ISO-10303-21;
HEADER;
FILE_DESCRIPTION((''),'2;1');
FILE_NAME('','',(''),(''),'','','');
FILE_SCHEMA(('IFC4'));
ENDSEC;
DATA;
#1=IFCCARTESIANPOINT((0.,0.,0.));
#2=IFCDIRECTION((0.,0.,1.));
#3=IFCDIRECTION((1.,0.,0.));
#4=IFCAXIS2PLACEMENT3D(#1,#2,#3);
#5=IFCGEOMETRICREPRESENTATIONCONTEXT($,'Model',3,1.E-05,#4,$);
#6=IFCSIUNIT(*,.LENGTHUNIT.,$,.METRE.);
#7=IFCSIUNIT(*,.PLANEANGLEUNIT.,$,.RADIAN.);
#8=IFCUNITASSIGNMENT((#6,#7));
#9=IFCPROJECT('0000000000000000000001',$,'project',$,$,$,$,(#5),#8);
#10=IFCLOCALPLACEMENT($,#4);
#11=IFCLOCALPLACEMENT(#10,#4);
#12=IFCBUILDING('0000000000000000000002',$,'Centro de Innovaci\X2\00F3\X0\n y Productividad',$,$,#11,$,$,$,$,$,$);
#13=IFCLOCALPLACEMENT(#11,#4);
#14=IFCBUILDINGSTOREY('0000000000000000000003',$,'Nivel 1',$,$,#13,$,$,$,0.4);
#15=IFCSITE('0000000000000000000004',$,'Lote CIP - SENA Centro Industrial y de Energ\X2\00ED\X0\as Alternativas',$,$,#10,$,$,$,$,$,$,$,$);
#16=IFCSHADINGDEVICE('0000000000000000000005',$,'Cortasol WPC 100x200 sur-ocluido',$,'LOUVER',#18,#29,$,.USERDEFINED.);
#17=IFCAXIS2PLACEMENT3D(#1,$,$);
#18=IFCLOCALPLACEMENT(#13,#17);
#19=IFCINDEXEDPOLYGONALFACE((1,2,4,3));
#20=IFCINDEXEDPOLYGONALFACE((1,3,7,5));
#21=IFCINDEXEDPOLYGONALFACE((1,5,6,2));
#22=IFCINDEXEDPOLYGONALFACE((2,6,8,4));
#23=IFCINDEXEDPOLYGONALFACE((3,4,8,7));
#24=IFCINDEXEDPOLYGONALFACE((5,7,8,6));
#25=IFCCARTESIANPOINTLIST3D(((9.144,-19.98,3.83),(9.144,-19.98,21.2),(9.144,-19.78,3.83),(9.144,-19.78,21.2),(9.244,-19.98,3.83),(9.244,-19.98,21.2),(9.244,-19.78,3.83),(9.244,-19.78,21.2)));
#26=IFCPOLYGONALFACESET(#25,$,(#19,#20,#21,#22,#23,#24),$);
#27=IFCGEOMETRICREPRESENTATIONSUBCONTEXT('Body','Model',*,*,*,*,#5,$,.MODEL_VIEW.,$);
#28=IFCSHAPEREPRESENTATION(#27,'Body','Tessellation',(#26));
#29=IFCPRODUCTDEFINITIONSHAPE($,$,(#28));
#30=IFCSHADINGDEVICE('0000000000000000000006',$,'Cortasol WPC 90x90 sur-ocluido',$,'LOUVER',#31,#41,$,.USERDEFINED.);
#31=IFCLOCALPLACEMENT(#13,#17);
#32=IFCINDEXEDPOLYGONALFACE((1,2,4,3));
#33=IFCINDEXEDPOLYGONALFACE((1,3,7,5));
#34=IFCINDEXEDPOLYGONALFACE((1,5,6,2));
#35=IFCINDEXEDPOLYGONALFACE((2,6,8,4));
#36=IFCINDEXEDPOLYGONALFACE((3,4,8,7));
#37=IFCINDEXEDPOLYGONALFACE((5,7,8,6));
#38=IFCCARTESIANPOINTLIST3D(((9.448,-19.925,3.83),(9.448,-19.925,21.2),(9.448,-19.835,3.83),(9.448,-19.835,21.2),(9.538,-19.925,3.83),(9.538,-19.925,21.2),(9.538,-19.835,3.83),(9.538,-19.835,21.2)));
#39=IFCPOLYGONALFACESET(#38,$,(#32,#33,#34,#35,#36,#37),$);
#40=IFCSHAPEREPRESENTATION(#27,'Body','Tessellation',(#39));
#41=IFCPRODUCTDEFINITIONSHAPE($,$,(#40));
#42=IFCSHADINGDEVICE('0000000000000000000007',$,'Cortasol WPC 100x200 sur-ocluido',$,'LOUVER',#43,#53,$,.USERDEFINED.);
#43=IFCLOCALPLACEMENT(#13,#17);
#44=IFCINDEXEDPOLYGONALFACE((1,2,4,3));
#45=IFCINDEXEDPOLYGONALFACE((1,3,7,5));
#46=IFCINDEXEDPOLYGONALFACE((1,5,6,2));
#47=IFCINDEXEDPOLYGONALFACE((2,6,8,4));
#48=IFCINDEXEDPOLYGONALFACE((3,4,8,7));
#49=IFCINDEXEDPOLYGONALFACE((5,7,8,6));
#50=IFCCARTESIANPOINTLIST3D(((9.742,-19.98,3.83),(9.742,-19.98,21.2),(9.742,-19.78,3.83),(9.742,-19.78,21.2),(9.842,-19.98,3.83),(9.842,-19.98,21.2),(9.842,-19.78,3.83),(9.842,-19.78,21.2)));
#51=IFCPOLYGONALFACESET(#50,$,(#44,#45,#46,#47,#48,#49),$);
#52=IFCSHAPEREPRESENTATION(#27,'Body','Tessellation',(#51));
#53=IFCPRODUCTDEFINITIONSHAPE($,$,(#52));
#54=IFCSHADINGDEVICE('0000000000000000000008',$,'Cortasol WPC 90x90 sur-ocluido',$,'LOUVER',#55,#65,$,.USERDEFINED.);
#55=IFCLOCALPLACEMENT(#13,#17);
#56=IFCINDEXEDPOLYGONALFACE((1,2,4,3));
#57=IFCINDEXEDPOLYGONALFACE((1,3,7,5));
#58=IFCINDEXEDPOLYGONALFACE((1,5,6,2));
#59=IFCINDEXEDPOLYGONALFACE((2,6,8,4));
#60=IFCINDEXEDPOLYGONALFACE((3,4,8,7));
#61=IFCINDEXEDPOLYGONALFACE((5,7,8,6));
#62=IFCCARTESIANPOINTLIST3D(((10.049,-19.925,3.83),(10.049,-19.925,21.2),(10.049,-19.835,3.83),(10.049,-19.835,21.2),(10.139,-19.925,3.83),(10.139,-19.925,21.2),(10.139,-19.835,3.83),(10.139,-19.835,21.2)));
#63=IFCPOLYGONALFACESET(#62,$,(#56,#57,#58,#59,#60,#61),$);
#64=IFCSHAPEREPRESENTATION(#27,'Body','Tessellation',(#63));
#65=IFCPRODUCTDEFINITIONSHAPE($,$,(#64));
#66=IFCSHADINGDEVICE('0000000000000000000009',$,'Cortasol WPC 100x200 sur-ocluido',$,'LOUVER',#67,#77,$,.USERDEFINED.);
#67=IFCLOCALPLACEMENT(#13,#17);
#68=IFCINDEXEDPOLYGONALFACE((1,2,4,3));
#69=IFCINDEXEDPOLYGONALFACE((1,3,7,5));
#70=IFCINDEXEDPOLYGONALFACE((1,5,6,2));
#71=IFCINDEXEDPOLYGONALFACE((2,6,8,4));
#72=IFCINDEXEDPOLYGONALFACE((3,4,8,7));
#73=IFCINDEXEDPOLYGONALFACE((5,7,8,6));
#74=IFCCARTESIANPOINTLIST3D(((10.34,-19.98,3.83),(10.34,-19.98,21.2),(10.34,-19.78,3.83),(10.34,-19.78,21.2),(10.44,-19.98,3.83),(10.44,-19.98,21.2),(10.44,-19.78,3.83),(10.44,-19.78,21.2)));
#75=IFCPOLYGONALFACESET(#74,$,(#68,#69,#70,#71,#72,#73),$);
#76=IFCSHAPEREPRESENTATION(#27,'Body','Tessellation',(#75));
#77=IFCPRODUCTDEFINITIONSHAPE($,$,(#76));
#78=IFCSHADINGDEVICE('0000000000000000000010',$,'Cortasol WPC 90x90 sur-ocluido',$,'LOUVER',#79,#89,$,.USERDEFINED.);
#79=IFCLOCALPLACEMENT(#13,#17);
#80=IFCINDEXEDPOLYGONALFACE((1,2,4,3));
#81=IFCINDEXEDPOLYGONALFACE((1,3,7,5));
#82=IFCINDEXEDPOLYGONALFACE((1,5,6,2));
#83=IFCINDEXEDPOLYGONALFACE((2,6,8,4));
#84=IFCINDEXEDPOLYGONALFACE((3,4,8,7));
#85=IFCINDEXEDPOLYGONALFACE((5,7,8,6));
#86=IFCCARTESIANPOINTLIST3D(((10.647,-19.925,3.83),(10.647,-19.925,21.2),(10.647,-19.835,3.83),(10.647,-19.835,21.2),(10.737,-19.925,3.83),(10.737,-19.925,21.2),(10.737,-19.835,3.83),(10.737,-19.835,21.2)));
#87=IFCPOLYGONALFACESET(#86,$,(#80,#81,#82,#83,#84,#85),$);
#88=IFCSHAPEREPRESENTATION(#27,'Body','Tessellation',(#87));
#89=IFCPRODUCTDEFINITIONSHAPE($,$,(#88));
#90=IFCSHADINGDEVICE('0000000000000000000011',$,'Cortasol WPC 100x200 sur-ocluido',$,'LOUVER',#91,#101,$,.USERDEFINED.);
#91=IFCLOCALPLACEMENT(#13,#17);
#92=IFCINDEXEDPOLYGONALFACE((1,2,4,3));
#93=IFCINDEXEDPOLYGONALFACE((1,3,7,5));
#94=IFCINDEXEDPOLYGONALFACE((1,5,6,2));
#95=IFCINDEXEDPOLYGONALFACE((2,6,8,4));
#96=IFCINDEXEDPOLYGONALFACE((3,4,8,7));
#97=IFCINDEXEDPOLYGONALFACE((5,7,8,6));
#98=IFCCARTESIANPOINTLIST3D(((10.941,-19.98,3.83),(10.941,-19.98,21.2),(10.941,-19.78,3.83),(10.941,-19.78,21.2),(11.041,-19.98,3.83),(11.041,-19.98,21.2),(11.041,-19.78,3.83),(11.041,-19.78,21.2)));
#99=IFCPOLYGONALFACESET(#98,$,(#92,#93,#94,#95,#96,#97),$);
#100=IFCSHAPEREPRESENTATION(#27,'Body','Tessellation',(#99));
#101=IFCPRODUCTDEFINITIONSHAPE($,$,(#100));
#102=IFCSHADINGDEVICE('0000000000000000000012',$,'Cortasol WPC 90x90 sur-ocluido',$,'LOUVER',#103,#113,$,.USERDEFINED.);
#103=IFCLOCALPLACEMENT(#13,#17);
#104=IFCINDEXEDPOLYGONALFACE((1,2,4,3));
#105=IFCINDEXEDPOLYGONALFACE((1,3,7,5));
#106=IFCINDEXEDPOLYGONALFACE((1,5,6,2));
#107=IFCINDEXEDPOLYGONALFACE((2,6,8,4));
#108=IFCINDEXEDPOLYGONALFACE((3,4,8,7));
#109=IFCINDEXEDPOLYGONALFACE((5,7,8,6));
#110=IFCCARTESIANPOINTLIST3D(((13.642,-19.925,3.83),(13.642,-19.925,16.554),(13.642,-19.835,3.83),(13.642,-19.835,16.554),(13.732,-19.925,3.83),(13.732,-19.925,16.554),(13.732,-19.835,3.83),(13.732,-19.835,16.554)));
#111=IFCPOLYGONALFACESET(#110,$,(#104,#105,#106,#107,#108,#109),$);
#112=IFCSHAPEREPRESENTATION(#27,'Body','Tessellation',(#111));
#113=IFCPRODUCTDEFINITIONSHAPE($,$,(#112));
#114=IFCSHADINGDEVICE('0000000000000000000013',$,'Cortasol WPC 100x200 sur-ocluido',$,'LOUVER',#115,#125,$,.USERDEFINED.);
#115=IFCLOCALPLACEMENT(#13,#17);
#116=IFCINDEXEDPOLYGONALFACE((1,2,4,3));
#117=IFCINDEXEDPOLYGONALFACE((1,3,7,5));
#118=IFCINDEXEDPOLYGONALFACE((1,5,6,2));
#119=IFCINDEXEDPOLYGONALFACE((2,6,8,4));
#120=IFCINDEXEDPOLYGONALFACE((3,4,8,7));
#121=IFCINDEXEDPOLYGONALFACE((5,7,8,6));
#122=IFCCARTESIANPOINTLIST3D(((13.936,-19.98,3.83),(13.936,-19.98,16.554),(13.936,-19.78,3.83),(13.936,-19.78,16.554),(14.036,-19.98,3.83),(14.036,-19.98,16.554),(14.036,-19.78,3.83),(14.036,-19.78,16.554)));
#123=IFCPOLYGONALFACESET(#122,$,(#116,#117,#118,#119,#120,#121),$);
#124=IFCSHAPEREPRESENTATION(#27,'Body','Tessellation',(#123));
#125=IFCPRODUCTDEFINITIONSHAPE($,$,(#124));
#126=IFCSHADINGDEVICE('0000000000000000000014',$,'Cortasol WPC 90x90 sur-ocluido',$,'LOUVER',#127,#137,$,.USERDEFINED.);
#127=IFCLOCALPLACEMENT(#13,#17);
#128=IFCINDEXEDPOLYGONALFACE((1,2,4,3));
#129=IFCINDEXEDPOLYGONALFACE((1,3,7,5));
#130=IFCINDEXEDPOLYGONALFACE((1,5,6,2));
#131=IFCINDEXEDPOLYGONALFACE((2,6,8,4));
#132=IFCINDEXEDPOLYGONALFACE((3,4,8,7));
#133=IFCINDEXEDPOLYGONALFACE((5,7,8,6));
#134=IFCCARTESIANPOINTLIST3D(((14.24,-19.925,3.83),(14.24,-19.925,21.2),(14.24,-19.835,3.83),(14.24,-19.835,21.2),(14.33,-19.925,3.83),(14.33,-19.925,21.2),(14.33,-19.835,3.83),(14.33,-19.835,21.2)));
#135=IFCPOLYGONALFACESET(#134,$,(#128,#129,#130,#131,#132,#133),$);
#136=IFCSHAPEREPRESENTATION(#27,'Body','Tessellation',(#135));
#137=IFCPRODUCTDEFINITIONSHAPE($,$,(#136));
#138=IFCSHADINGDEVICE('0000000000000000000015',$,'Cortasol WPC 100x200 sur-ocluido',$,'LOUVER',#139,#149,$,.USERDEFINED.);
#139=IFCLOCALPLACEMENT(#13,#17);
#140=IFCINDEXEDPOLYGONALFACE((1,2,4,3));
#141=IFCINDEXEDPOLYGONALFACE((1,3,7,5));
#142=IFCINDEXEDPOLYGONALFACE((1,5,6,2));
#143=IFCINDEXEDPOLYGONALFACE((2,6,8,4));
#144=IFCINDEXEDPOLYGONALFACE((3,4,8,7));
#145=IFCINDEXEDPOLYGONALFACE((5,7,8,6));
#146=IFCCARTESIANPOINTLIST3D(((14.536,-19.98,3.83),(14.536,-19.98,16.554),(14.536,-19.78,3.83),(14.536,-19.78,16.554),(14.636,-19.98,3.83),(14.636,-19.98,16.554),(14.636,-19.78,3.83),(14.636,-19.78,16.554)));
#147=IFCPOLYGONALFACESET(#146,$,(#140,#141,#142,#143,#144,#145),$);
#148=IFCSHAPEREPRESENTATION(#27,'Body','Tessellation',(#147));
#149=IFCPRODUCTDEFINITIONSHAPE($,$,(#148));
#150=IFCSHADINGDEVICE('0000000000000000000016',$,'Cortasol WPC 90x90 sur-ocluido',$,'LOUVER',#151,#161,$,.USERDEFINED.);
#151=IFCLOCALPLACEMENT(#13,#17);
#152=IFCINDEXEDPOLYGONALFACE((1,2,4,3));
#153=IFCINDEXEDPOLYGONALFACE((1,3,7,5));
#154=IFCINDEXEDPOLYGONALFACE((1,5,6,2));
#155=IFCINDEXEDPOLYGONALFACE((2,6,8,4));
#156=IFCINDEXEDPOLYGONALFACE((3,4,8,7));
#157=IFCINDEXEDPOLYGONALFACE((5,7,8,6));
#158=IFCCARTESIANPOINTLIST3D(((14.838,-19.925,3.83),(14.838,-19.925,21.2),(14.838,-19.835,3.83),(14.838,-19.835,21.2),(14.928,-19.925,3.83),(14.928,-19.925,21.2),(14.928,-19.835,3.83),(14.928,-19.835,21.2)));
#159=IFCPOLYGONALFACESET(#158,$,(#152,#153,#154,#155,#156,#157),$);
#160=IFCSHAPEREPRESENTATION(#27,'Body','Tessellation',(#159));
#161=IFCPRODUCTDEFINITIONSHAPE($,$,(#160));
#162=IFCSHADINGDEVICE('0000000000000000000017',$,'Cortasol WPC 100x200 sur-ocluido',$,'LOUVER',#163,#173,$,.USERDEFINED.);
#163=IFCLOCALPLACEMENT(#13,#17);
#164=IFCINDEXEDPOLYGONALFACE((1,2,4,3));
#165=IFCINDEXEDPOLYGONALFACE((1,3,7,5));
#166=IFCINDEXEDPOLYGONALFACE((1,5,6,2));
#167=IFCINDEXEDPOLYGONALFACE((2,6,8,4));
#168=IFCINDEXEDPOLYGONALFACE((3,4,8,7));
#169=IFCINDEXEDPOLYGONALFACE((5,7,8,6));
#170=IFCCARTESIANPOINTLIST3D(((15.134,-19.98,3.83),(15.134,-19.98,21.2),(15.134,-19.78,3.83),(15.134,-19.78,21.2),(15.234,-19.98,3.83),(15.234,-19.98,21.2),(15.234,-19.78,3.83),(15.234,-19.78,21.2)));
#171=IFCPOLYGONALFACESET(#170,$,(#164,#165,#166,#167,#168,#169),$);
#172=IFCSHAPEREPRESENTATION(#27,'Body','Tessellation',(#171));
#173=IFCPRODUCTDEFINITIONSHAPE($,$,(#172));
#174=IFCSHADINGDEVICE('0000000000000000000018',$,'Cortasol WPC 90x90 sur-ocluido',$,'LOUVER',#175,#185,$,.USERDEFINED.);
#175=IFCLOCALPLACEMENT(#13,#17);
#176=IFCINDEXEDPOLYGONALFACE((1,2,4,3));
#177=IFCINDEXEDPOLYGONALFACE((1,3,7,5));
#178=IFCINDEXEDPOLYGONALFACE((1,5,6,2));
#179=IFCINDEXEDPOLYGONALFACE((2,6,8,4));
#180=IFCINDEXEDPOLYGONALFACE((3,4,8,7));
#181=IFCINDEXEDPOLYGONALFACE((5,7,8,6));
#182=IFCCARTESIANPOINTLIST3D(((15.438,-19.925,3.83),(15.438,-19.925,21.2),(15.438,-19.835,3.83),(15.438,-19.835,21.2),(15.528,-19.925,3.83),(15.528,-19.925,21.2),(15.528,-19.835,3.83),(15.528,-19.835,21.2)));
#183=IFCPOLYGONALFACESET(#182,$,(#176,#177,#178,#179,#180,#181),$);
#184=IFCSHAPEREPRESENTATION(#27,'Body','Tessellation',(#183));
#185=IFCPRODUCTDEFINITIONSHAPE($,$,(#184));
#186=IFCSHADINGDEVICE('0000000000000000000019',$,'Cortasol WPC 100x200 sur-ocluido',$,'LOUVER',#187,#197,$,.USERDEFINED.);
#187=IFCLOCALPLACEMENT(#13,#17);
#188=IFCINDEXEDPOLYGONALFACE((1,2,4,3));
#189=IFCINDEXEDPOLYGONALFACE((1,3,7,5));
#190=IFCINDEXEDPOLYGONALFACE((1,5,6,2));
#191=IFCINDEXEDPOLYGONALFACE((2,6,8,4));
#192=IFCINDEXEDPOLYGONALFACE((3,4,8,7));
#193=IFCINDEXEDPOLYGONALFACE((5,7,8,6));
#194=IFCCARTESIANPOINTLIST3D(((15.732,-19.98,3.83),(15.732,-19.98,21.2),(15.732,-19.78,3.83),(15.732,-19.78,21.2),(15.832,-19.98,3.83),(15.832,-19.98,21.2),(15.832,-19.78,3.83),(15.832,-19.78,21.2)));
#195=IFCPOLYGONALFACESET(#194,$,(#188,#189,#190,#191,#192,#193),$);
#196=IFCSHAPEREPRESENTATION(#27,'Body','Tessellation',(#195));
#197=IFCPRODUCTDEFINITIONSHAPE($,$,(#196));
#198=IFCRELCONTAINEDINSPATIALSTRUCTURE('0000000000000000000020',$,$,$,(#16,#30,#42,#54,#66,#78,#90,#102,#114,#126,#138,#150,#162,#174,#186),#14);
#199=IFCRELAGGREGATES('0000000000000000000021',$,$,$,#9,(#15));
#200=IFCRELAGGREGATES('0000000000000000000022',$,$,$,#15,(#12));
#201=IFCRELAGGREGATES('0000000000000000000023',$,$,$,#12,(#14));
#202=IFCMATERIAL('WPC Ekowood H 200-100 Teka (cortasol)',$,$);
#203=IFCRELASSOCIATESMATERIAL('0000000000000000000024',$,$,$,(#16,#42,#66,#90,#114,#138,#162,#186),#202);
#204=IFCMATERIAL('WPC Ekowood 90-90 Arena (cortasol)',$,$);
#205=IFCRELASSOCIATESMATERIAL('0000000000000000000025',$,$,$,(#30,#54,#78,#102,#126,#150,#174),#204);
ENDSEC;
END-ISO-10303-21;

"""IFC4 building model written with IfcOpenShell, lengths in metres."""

from ifc_helpers import new_model, si_unit, frame, origin_with_axes, place, context, subcontext, project, spatial, polyline, outline, extrude, material, element, save


model = new_model("IFC4")

# Units and contexts
model_context = context("Model", 3, precision=1e-05, world=origin_with_axes())
body_context = subcontext(model_context, "Body", "Model", "MODEL_VIEW")
ifc_project = project(units=[si_unit("LENGTHUNIT", "METRE"), si_unit("PLANEANGLEUNIT", "RADIAN")], contexts=[model_context])

# Site, building, storey
site_placement = place(None, origin_with_axes())
site = spatial("IfcSite", under=ifc_project, at=site_placement, Name="Lote CIP - SENA Centro Industrial y de Energías Alternativas")
building_placement = place(site_placement, origin_with_axes())
building = spatial("IfcBuilding", under=site, at=building_placement, Name="Centro de Innovación y Productividad")
storey_placement = place(building_placement, origin_with_axes())
storey = spatial("IfcBuildingStorey", under=building, at=storey_placement, Name="Nivel 1", Elevation=0.4)

# Shading devices
ifc_material_1 = material(Name="WPC Ekowood H 200-100 Teka (cortasol)")
shading_device_1_placement = place(storey_placement, origin_with_axes())
element("IfcShadingDevice", 1, at=shading_device_1_placement, inside=storey, material=ifc_material_1, Name="Cortasol WPC 100x200 sur-ocluido", ObjectType="LOUVER", PredefinedType="USERDEFINED", context=body_context, shape_type="SweptSolid", body=[
    extrude(outline(polyline([(9.144, -19.98), (9.144, -19.78), (9.244, -19.78), (9.244, -19.98), (9.144, -19.98)])), frame((0.0, 0.0, 3.83)), (0.0, 0.0, 1.0), 17.37),
])
ifc_material_2 = material(Name="WPC Ekowood 90-90 Arena (cortasol)")
shading_device_2_placement = place(storey_placement, origin_with_axes())
element("IfcShadingDevice", 2, at=shading_device_2_placement, inside=storey, material=ifc_material_2, Name="Cortasol WPC 90x90 sur-ocluido", ObjectType="LOUVER", PredefinedType="USERDEFINED", context=body_context, shape_type="SweptSolid", body=[
    extrude(outline(polyline([(9.448, -19.925), (9.448, -19.835), (9.538, -19.835), (9.538, -19.925), (9.448, -19.925)])), frame((0.0, 0.0, 3.83)), (0.0, 0.0, 1.0), 17.37),
])
shading_device_3_placement = place(storey_placement, origin_with_axes())
element("IfcShadingDevice", 3, at=shading_device_3_placement, inside=storey, material=ifc_material_1, Name="Cortasol WPC 100x200 sur-ocluido", ObjectType="LOUVER", PredefinedType="USERDEFINED", context=body_context, shape_type="SweptSolid", body=[
    extrude(outline(polyline([(9.742, -19.98), (9.742, -19.78), (9.842, -19.78), (9.842, -19.98), (9.742, -19.98)])), frame((0.0, 0.0, 3.83)), (0.0, 0.0, 1.0), 17.37),
])
shading_device_4_placement = place(storey_placement, origin_with_axes())
element("IfcShadingDevice", 4, at=shading_device_4_placement, inside=storey, material=ifc_material_2, Name="Cortasol WPC 90x90 sur-ocluido", ObjectType="LOUVER", PredefinedType="USERDEFINED", context=body_context, shape_type="SweptSolid", body=[
    extrude(outline(polyline([(10.049, -19.925), (10.049, -19.835), (10.139, -19.835), (10.139, -19.925), (10.049, -19.925)])), frame((0.0, 0.0, 3.83)), (0.0, 0.0, 1.0), 17.37),
])
shading_device_5_placement = place(storey_placement, origin_with_axes())
element("IfcShadingDevice", 5, at=shading_device_5_placement, inside=storey, material=ifc_material_1, Name="Cortasol WPC 100x200 sur-ocluido", ObjectType="LOUVER", PredefinedType="USERDEFINED", context=body_context, shape_type="SweptSolid", body=[
    extrude(outline(polyline([(10.34, -19.98), (10.34, -19.78), (10.44, -19.78), (10.44, -19.98), (10.34, -19.98)])), frame((0.0, 0.0, 3.83)), (0.0, 0.0, 1.0), 17.37),
])
shading_device_6_placement = place(storey_placement, origin_with_axes())
element("IfcShadingDevice", 6, at=shading_device_6_placement, inside=storey, material=ifc_material_2, Name="Cortasol WPC 90x90 sur-ocluido", ObjectType="LOUVER", PredefinedType="USERDEFINED", context=body_context, shape_type="SweptSolid", body=[
    extrude(outline(polyline([(10.647, -19.925), (10.647, -19.835), (10.737, -19.835), (10.737, -19.925), (10.647, -19.925)])), frame((0.0, 0.0, 3.83)), (0.0, 0.0, 1.0), 17.37),
])
shading_device_7_placement = place(storey_placement, origin_with_axes())
element("IfcShadingDevice", 7, at=shading_device_7_placement, inside=storey, material=ifc_material_1, Name="Cortasol WPC 100x200 sur-ocluido", ObjectType="LOUVER", PredefinedType="USERDEFINED", context=body_context, shape_type="SweptSolid", body=[
    extrude(outline(polyline([(10.941, -19.98), (10.941, -19.78), (11.041, -19.78), (11.041, -19.98), (10.941, -19.98)])), frame((0.0, 0.0, 3.83)), (0.0, 0.0, 1.0), 17.37),
])
shading_device_8_placement = place(storey_placement, origin_with_axes())
element("IfcShadingDevice", 8, at=shading_device_8_placement, inside=storey, material=ifc_material_2, Name="Cortasol WPC 90x90 sur-ocluido", ObjectType="LOUVER", PredefinedType="USERDEFINED", context=body_context, shape_type="SweptSolid", body=[
    extrude(outline(polyline([(13.642, -19.925), (13.642, -19.835), (13.732, -19.835), (13.732, -19.925), (13.642, -19.925)])), frame((0.0, 0.0, 3.83)), (0.0, 0.0, 1.0), 12.724),
])
shading_device_9_placement = place(storey_placement, origin_with_axes())
element("IfcShadingDevice", 9, at=shading_device_9_placement, inside=storey, material=ifc_material_1, Name="Cortasol WPC 100x200 sur-ocluido", ObjectType="LOUVER", PredefinedType="USERDEFINED", context=body_context, shape_type="SweptSolid", body=[
    extrude(outline(polyline([(13.936, -19.98), (13.936, -19.78), (14.036, -19.78), (14.036, -19.98), (13.936, -19.98)])), frame((0.0, 0.0, 3.83)), (0.0, 0.0, 1.0), 12.724),
])
shading_device_10_placement = place(storey_placement, origin_with_axes())
element("IfcShadingDevice", 10, at=shading_device_10_placement, inside=storey, material=ifc_material_2, Name="Cortasol WPC 90x90 sur-ocluido", ObjectType="LOUVER", PredefinedType="USERDEFINED", context=body_context, shape_type="SweptSolid", body=[
    extrude(outline(polyline([(14.24, -19.925), (14.24, -19.835), (14.33, -19.835), (14.33, -19.925), (14.24, -19.925)])), frame((0.0, 0.0, 3.83)), (0.0, 0.0, 1.0), 17.37),
])
shading_device_11_placement = place(storey_placement, origin_with_axes())
element("IfcShadingDevice", 11, at=shading_device_11_placement, inside=storey, material=ifc_material_1, Name="Cortasol WPC 100x200 sur-ocluido", ObjectType="LOUVER", PredefinedType="USERDEFINED", context=body_context, shape_type="SweptSolid", body=[
    extrude(outline(polyline([(14.536, -19.98), (14.536, -19.78), (14.636, -19.78), (14.636, -19.98), (14.536, -19.98)])), frame((0.0, 0.0, 3.83)), (0.0, 0.0, 1.0), 12.724),
])
shading_device_12_placement = place(storey_placement, origin_with_axes())
element("IfcShadingDevice", 12, at=shading_device_12_placement, inside=storey, material=ifc_material_2, Name="Cortasol WPC 90x90 sur-ocluido", ObjectType="LOUVER", PredefinedType="USERDEFINED", context=body_context, shape_type="SweptSolid", body=[
    extrude(outline(polyline([(14.838, -19.925), (14.838, -19.835), (14.928, -19.835), (14.928, -19.925), (14.838, -19.925)])), frame((0.0, 0.0, 3.83)), (0.0, 0.0, 1.0), 17.37),
])
shading_device_13_placement = place(storey_placement, origin_with_axes())
element("IfcShadingDevice", 13, at=shading_device_13_placement, inside=storey, material=ifc_material_1, Name="Cortasol WPC 100x200 sur-ocluido", ObjectType="LOUVER", PredefinedType="USERDEFINED", context=body_context, shape_type="SweptSolid", body=[
    extrude(outline(polyline([(15.134, -19.98), (15.134, -19.78), (15.234, -19.78), (15.234, -19.98), (15.134, -19.98)])), frame((0.0, 0.0, 3.83)), (0.0, 0.0, 1.0), 17.37),
])
shading_device_14_placement = place(storey_placement, origin_with_axes())
element("IfcShadingDevice", 14, at=shading_device_14_placement, inside=storey, material=ifc_material_2, Name="Cortasol WPC 90x90 sur-ocluido", ObjectType="LOUVER", PredefinedType="USERDEFINED", context=body_context, shape_type="SweptSolid", body=[
    extrude(outline(polyline([(15.438, -19.925), (15.438, -19.835), (15.528, -19.835), (15.528, -19.925), (15.438, -19.925)])), frame((0.0, 0.0, 3.83)), (0.0, 0.0, 1.0), 17.37),
])
shading_device_15_placement = place(storey_placement, origin_with_axes())
element("IfcShadingDevice", 15, at=shading_device_15_placement, inside=storey, material=ifc_material_1, Name="Cortasol WPC 100x200 sur-ocluido", ObjectType="LOUVER", PredefinedType="USERDEFINED", context=body_context, shape_type="SweptSolid", body=[
    extrude(outline(polyline([(15.732, -19.98), (15.732, -19.78), (15.832, -19.78), (15.832, -19.98), (15.732, -19.98)])), frame((0.0, 0.0, 3.83)), (0.0, 0.0, 1.0), 17.37),
])

save(model, "model.ifc")
